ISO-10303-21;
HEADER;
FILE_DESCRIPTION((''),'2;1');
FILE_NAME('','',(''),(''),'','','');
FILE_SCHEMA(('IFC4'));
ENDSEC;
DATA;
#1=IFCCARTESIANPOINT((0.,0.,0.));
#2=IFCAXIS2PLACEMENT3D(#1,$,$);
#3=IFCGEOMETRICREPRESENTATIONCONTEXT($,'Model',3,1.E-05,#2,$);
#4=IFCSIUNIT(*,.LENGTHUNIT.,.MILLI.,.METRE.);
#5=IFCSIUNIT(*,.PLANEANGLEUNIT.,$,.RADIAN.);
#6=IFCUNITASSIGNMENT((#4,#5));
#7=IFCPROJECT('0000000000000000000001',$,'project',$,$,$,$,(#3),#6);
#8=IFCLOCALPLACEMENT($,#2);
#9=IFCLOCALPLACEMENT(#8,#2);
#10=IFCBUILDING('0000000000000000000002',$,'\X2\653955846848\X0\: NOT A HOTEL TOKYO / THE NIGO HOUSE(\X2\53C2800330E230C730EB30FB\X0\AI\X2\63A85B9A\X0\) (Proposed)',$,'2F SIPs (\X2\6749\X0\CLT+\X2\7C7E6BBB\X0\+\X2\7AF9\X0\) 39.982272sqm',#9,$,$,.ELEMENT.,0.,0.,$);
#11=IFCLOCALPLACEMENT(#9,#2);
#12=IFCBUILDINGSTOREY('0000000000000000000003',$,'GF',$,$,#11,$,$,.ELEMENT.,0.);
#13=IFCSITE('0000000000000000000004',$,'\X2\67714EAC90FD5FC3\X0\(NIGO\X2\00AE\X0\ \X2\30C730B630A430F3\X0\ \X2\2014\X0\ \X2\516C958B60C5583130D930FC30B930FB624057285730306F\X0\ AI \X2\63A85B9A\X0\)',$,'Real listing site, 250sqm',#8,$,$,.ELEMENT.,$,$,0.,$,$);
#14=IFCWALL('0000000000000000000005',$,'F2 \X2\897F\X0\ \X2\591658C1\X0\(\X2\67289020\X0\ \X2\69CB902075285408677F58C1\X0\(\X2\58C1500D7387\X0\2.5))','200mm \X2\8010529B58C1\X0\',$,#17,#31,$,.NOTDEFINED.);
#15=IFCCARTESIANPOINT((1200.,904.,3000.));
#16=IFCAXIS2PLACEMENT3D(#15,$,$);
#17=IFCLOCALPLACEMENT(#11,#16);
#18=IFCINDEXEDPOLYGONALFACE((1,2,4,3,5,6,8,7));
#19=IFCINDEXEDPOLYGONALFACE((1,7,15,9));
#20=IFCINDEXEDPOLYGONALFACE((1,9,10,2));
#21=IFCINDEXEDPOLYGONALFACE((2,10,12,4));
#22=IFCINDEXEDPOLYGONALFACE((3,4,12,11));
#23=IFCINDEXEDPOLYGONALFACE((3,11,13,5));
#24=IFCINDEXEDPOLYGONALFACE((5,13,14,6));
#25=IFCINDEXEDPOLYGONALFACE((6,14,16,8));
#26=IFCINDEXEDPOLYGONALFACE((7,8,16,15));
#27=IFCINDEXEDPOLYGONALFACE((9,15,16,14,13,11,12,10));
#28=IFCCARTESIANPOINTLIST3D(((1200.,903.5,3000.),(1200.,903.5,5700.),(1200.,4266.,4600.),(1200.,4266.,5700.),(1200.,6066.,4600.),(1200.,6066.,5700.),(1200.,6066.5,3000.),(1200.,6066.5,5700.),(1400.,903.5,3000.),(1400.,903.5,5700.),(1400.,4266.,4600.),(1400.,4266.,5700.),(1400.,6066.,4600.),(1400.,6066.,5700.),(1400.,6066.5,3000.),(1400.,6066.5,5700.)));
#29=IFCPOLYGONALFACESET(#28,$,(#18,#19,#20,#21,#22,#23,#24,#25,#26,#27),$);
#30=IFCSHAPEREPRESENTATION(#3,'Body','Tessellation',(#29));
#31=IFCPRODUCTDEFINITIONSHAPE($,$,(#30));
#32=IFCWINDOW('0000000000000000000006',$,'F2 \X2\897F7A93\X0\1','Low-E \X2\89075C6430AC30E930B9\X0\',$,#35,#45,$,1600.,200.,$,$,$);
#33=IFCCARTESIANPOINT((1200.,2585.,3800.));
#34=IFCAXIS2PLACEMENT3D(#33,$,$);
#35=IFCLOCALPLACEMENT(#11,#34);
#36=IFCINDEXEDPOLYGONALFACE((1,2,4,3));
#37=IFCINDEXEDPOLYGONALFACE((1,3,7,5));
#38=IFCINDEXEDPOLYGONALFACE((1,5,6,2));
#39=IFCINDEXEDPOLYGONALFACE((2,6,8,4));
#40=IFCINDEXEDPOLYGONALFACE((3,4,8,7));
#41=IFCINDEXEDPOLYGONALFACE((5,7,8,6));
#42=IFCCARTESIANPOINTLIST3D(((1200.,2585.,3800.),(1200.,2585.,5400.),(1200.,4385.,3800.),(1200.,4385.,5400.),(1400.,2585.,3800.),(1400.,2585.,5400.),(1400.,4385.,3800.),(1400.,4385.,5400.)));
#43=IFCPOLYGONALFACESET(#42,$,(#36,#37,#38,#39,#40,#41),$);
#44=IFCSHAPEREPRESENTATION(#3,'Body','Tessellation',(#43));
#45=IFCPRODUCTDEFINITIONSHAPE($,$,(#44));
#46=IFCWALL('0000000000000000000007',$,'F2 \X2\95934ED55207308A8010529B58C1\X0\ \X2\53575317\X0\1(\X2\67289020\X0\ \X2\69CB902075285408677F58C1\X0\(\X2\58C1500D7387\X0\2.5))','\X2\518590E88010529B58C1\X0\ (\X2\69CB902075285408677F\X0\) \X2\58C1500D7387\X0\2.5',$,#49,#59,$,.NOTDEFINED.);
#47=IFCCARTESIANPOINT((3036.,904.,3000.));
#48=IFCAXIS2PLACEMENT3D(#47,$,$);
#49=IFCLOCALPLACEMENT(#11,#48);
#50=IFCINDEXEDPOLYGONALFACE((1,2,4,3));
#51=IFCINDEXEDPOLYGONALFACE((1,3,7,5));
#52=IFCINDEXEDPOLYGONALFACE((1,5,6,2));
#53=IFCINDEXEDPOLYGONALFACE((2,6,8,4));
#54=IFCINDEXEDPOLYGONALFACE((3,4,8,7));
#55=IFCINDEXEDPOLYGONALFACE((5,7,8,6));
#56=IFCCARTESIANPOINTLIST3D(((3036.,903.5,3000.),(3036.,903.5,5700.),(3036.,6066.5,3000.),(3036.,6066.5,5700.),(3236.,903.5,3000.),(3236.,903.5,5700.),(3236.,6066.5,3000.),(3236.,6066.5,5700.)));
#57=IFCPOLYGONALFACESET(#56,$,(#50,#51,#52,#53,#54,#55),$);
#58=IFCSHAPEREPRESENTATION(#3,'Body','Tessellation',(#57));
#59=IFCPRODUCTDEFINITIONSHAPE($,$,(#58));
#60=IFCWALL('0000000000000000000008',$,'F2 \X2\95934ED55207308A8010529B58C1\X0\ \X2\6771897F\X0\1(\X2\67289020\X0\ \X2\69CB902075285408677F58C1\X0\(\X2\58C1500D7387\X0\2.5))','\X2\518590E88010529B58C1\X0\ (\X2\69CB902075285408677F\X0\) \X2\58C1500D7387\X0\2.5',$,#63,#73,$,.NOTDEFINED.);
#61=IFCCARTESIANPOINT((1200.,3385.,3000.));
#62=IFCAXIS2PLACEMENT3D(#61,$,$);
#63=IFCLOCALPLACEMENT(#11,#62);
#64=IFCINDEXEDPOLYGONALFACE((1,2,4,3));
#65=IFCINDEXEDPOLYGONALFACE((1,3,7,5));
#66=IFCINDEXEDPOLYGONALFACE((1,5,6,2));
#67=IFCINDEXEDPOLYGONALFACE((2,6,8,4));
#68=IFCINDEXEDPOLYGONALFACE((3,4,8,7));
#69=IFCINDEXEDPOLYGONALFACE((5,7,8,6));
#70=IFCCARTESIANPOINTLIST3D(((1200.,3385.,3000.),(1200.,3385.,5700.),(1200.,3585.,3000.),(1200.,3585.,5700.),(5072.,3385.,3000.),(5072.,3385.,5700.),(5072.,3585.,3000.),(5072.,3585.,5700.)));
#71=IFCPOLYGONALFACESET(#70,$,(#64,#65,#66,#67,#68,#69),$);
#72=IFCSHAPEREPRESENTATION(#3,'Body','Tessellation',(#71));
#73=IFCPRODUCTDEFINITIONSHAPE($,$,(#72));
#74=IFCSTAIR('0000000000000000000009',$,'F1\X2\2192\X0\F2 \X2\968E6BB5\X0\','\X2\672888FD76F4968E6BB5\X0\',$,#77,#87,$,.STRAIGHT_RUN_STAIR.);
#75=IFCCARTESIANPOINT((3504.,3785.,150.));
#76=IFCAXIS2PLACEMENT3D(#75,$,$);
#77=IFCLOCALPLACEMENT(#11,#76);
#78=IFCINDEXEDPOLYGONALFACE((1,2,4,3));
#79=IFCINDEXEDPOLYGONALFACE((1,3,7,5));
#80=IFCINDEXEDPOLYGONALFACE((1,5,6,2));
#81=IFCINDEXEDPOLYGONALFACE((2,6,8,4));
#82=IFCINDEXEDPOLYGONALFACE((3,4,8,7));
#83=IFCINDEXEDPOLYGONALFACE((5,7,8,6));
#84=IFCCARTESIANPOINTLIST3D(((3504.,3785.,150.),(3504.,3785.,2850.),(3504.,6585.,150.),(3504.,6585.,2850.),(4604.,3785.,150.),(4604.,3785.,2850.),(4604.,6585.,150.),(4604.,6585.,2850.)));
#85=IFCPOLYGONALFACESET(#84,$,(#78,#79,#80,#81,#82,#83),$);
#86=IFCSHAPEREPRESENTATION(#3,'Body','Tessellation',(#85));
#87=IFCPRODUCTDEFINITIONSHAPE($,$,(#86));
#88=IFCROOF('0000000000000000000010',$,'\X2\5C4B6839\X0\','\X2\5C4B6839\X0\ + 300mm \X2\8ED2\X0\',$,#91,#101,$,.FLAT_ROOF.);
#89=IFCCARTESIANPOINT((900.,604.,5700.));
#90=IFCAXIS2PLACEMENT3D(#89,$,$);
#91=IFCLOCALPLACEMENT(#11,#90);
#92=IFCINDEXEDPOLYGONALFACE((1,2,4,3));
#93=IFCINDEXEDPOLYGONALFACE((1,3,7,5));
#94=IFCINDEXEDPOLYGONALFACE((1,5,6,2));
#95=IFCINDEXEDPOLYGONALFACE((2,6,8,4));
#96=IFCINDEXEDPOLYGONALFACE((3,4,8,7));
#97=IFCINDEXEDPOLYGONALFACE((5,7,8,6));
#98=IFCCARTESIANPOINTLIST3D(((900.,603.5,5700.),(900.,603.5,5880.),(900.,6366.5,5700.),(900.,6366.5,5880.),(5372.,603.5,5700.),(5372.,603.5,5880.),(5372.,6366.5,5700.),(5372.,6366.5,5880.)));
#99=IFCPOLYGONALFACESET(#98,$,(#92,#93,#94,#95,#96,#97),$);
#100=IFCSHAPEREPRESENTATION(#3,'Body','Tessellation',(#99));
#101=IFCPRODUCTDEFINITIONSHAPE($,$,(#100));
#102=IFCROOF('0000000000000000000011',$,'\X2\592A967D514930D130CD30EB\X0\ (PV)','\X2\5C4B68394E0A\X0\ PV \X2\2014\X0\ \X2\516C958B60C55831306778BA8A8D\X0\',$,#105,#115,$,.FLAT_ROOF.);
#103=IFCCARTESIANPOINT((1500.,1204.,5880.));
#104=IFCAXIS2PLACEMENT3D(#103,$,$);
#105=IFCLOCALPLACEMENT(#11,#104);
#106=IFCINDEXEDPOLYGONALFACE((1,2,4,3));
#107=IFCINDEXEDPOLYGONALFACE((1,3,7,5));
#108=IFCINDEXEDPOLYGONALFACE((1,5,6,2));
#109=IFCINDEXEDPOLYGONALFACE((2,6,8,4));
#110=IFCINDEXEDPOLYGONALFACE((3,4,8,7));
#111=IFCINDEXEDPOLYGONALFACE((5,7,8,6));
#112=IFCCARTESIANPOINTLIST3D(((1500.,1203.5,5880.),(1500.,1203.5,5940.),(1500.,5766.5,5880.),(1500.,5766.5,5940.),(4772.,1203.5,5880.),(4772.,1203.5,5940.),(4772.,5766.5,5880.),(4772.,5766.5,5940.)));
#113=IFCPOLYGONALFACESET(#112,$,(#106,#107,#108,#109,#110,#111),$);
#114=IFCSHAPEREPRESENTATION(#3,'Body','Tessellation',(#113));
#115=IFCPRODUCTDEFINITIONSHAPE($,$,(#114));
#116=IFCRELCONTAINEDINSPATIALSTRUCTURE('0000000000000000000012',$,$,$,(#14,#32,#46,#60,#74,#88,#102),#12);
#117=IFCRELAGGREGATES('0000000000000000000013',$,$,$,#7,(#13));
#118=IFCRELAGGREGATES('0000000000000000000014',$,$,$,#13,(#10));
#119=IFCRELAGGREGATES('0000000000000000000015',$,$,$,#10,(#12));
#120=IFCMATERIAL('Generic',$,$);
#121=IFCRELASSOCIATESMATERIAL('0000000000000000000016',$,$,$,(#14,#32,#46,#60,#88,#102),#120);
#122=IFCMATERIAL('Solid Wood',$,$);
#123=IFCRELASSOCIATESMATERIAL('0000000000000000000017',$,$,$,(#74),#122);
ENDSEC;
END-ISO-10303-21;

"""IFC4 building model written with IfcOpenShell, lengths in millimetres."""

from ifc_helpers import new_model, si_unit, frame, frame_2d, origin, place, context, project, spatial, rectangle, extrude, material, element, fill, save


model = new_model("IFC4")

# Units and contexts
model_context = context("Model", 3, precision=1e-05, world=origin())
ifc_project = project(units=[si_unit("LENGTHUNIT", "METRE", prefix="MILLI"), si_unit("PLANEANGLEUNIT", "RADIAN")], contexts=[model_context])

# Site, building, storey
site_placement = place(None, origin())
site = spatial("IfcSite", under=ifc_project, at=site_placement, Name="東京都心(NIGO® デザイン — 公開情報ベース・所在地は AI 推定)", ObjectType="Real listing site, 250sqm", CompositionType="ELEMENT", RefElevation=0.0)
building_placement = place(site_placement, origin())
building = spatial("IfcBuilding", under=site, at=building_placement, Name="改善案: NOT A HOTEL TOKYO / THE NIGO HOUSE(参考モデル・AI推定) (Proposed)", ObjectType="2F SIPs (杉CLT+籾殻+竹) 39.982272sqm", CompositionType="ELEMENT", ElevationOfRefHeight=0.0, ElevationOfTerrain=0.0)
storey_placement = place(building_placement, origin())
storey = spatial("IfcBuildingStorey", under=building, at=storey_placement, Name="GF", CompositionType="ELEMENT", Elevation=0.0)

# Shared definitions
ifc_material_1 = material(Name="Generic")

# Shared definitions
ifc_material_2 = material(Name="Solid Wood")

# Wall, opening, window
wall_1_placement = place(storey_placement, frame((1200.0, 904.0, 3000.0)))
wall_1 = element("IfcWall", 1, at=wall_1_placement, inside=storey, material=ifc_material_1, Name="F2 西 外壁(木造 構造用合板壁(壁倍率2.5))", Description="200mm 耐力壁", PredefinedType="NOTDEFINED", context=model_context, shape_type="SweptSolid", body=[
    extrude(rectangle(XDim=200.0, YDim=5163.0, at=frame_2d((100.0, 2581.0))), frame((1200.0, 904.0, 3000.0)), (0.0, 0.0, 1.0), 2700.0),
])
opening_1_placement = place(storey_placement, frame((1200.0, 2585.0, 3800.0)))
opening_1 = element("IfcOpeningElement", 2, at=opening_1_placement, cuts=wall_1, PredefinedType="NOTDEFINED", context=model_context, shape_type="SweptSolid", body=[
    extrude(rectangle(XDim=200.0, YDim=1800.0, at=frame_2d((100.0, 900.0))), frame((1200.0, 2585.0, 3800.0)), (0.0, 0.0, 1.0), 1600.0),
])
window_1_placement = place(storey_placement, frame((1200.0, 2585.0, 3800.0)))
window_1 = element("IfcWindow", 3, at=window_1_placement, inside=storey, material=ifc_material_1, Name="F2 西窓1", Description="Low-E 複層ガラス", OverallHeight=1600.0, OverallWidth=200.0, context=model_context, shape_type="SweptSolid", body=[
    extrude(rectangle(XDim=200.0, YDim=1800.0, at=frame_2d((100.0, 900.0))), frame((1200.0, 2585.0, 3800.0)), (0.0, 0.0, 1.0), 1600.0),
])
fill(opening_1, window_1)

# Walls
wall_2_placement = place(storey_placement, frame((3036.0, 904.0, 3000.0)))
element("IfcWall", 4, at=wall_2_placement, inside=storey, material=ifc_material_1, Name="F2 間仕切り耐力壁 南北1(木造 構造用合板壁(壁倍率2.5))", Description="内部耐力壁 (構造用合板) 壁倍率2.5", PredefinedType="NOTDEFINED", context=model_context, shape_type="SweptSolid", body=[
    extrude(rectangle(XDim=200.0, YDim=5163.0, at=frame_2d((100.0, 2581.0))), frame((3036.0, 904.0, 3000.0)), (0.0, 0.0, 1.0), 2700.0),
])
wall_3_placement = place(storey_placement, frame((1200.0, 3385.0, 3000.0)))
element("IfcWall", 5, at=wall_3_placement, inside=storey, material=ifc_material_1, Name="F2 間仕切り耐力壁 東西1(木造 構造用合板壁(壁倍率2.5))", Description="内部耐力壁 (構造用合板) 壁倍率2.5", PredefinedType="NOTDEFINED", context=model_context, shape_type="SweptSolid", body=[
    extrude(rectangle(XDim=3872.0, YDim=200.0, at=frame_2d((1936.0, 100.0))), frame((1200.0, 3385.0, 3000.0)), (0.0, 0.0, 1.0), 2700.0),
])

# Stair
stair_placement = place(storey_placement, frame((3504.0, 3785.0, 150.0)))
element("IfcStair", 6, at=stair_placement, inside=storey, material=ifc_material_2, Name="F1→F2 階段", Description="木製直階段", PredefinedType="STRAIGHT_RUN_STAIR", context=model_context, shape_type="SweptSolid", body=[
    extrude(rectangle(XDim=1100.0, YDim=2800.0, at=frame_2d((550.0, 1400.0))), frame((3504.0, 3785.0, 150.0)), (0.0, 0.0, 1.0), 2700.0),
])

# Roofs
roof_1_placement = place(storey_placement, frame((900.0, 604.0, 5700.0)))
element("IfcRoof", 7, at=roof_1_placement, inside=storey, material=ifc_material_1, Name="屋根", Description="屋根 + 300mm 軒", PredefinedType="FLAT_ROOF", context=model_context, shape_type="SweptSolid", body=[
    extrude(rectangle(XDim=4472.0, YDim=5763.0, at=frame_2d((2236.0, 2881.0))), frame((900.0, 604.0, 5700.0)), (0.0, 0.0, 1.0), 180.0),
])
roof_2_placement = place(storey_placement, frame((1500.0, 1204.0, 5880.0)))
element("IfcRoof", 8, at=roof_2_placement, inside=storey, material=ifc_material_1, Name="太陽光パネル (PV)", Description="屋根上 PV — 公開情報で確認", PredefinedType="FLAT_ROOF", context=model_context, shape_type="SweptSolid", body=[
    extrude(rectangle(XDim=3272.0, YDim=4563.0, at=frame_2d((1636.0, 2281.0))), frame((1500.0, 1204.0, 5880.0)), (0.0, 0.0, 1.0), 60.0),
])

save(model, "model.ifc")
